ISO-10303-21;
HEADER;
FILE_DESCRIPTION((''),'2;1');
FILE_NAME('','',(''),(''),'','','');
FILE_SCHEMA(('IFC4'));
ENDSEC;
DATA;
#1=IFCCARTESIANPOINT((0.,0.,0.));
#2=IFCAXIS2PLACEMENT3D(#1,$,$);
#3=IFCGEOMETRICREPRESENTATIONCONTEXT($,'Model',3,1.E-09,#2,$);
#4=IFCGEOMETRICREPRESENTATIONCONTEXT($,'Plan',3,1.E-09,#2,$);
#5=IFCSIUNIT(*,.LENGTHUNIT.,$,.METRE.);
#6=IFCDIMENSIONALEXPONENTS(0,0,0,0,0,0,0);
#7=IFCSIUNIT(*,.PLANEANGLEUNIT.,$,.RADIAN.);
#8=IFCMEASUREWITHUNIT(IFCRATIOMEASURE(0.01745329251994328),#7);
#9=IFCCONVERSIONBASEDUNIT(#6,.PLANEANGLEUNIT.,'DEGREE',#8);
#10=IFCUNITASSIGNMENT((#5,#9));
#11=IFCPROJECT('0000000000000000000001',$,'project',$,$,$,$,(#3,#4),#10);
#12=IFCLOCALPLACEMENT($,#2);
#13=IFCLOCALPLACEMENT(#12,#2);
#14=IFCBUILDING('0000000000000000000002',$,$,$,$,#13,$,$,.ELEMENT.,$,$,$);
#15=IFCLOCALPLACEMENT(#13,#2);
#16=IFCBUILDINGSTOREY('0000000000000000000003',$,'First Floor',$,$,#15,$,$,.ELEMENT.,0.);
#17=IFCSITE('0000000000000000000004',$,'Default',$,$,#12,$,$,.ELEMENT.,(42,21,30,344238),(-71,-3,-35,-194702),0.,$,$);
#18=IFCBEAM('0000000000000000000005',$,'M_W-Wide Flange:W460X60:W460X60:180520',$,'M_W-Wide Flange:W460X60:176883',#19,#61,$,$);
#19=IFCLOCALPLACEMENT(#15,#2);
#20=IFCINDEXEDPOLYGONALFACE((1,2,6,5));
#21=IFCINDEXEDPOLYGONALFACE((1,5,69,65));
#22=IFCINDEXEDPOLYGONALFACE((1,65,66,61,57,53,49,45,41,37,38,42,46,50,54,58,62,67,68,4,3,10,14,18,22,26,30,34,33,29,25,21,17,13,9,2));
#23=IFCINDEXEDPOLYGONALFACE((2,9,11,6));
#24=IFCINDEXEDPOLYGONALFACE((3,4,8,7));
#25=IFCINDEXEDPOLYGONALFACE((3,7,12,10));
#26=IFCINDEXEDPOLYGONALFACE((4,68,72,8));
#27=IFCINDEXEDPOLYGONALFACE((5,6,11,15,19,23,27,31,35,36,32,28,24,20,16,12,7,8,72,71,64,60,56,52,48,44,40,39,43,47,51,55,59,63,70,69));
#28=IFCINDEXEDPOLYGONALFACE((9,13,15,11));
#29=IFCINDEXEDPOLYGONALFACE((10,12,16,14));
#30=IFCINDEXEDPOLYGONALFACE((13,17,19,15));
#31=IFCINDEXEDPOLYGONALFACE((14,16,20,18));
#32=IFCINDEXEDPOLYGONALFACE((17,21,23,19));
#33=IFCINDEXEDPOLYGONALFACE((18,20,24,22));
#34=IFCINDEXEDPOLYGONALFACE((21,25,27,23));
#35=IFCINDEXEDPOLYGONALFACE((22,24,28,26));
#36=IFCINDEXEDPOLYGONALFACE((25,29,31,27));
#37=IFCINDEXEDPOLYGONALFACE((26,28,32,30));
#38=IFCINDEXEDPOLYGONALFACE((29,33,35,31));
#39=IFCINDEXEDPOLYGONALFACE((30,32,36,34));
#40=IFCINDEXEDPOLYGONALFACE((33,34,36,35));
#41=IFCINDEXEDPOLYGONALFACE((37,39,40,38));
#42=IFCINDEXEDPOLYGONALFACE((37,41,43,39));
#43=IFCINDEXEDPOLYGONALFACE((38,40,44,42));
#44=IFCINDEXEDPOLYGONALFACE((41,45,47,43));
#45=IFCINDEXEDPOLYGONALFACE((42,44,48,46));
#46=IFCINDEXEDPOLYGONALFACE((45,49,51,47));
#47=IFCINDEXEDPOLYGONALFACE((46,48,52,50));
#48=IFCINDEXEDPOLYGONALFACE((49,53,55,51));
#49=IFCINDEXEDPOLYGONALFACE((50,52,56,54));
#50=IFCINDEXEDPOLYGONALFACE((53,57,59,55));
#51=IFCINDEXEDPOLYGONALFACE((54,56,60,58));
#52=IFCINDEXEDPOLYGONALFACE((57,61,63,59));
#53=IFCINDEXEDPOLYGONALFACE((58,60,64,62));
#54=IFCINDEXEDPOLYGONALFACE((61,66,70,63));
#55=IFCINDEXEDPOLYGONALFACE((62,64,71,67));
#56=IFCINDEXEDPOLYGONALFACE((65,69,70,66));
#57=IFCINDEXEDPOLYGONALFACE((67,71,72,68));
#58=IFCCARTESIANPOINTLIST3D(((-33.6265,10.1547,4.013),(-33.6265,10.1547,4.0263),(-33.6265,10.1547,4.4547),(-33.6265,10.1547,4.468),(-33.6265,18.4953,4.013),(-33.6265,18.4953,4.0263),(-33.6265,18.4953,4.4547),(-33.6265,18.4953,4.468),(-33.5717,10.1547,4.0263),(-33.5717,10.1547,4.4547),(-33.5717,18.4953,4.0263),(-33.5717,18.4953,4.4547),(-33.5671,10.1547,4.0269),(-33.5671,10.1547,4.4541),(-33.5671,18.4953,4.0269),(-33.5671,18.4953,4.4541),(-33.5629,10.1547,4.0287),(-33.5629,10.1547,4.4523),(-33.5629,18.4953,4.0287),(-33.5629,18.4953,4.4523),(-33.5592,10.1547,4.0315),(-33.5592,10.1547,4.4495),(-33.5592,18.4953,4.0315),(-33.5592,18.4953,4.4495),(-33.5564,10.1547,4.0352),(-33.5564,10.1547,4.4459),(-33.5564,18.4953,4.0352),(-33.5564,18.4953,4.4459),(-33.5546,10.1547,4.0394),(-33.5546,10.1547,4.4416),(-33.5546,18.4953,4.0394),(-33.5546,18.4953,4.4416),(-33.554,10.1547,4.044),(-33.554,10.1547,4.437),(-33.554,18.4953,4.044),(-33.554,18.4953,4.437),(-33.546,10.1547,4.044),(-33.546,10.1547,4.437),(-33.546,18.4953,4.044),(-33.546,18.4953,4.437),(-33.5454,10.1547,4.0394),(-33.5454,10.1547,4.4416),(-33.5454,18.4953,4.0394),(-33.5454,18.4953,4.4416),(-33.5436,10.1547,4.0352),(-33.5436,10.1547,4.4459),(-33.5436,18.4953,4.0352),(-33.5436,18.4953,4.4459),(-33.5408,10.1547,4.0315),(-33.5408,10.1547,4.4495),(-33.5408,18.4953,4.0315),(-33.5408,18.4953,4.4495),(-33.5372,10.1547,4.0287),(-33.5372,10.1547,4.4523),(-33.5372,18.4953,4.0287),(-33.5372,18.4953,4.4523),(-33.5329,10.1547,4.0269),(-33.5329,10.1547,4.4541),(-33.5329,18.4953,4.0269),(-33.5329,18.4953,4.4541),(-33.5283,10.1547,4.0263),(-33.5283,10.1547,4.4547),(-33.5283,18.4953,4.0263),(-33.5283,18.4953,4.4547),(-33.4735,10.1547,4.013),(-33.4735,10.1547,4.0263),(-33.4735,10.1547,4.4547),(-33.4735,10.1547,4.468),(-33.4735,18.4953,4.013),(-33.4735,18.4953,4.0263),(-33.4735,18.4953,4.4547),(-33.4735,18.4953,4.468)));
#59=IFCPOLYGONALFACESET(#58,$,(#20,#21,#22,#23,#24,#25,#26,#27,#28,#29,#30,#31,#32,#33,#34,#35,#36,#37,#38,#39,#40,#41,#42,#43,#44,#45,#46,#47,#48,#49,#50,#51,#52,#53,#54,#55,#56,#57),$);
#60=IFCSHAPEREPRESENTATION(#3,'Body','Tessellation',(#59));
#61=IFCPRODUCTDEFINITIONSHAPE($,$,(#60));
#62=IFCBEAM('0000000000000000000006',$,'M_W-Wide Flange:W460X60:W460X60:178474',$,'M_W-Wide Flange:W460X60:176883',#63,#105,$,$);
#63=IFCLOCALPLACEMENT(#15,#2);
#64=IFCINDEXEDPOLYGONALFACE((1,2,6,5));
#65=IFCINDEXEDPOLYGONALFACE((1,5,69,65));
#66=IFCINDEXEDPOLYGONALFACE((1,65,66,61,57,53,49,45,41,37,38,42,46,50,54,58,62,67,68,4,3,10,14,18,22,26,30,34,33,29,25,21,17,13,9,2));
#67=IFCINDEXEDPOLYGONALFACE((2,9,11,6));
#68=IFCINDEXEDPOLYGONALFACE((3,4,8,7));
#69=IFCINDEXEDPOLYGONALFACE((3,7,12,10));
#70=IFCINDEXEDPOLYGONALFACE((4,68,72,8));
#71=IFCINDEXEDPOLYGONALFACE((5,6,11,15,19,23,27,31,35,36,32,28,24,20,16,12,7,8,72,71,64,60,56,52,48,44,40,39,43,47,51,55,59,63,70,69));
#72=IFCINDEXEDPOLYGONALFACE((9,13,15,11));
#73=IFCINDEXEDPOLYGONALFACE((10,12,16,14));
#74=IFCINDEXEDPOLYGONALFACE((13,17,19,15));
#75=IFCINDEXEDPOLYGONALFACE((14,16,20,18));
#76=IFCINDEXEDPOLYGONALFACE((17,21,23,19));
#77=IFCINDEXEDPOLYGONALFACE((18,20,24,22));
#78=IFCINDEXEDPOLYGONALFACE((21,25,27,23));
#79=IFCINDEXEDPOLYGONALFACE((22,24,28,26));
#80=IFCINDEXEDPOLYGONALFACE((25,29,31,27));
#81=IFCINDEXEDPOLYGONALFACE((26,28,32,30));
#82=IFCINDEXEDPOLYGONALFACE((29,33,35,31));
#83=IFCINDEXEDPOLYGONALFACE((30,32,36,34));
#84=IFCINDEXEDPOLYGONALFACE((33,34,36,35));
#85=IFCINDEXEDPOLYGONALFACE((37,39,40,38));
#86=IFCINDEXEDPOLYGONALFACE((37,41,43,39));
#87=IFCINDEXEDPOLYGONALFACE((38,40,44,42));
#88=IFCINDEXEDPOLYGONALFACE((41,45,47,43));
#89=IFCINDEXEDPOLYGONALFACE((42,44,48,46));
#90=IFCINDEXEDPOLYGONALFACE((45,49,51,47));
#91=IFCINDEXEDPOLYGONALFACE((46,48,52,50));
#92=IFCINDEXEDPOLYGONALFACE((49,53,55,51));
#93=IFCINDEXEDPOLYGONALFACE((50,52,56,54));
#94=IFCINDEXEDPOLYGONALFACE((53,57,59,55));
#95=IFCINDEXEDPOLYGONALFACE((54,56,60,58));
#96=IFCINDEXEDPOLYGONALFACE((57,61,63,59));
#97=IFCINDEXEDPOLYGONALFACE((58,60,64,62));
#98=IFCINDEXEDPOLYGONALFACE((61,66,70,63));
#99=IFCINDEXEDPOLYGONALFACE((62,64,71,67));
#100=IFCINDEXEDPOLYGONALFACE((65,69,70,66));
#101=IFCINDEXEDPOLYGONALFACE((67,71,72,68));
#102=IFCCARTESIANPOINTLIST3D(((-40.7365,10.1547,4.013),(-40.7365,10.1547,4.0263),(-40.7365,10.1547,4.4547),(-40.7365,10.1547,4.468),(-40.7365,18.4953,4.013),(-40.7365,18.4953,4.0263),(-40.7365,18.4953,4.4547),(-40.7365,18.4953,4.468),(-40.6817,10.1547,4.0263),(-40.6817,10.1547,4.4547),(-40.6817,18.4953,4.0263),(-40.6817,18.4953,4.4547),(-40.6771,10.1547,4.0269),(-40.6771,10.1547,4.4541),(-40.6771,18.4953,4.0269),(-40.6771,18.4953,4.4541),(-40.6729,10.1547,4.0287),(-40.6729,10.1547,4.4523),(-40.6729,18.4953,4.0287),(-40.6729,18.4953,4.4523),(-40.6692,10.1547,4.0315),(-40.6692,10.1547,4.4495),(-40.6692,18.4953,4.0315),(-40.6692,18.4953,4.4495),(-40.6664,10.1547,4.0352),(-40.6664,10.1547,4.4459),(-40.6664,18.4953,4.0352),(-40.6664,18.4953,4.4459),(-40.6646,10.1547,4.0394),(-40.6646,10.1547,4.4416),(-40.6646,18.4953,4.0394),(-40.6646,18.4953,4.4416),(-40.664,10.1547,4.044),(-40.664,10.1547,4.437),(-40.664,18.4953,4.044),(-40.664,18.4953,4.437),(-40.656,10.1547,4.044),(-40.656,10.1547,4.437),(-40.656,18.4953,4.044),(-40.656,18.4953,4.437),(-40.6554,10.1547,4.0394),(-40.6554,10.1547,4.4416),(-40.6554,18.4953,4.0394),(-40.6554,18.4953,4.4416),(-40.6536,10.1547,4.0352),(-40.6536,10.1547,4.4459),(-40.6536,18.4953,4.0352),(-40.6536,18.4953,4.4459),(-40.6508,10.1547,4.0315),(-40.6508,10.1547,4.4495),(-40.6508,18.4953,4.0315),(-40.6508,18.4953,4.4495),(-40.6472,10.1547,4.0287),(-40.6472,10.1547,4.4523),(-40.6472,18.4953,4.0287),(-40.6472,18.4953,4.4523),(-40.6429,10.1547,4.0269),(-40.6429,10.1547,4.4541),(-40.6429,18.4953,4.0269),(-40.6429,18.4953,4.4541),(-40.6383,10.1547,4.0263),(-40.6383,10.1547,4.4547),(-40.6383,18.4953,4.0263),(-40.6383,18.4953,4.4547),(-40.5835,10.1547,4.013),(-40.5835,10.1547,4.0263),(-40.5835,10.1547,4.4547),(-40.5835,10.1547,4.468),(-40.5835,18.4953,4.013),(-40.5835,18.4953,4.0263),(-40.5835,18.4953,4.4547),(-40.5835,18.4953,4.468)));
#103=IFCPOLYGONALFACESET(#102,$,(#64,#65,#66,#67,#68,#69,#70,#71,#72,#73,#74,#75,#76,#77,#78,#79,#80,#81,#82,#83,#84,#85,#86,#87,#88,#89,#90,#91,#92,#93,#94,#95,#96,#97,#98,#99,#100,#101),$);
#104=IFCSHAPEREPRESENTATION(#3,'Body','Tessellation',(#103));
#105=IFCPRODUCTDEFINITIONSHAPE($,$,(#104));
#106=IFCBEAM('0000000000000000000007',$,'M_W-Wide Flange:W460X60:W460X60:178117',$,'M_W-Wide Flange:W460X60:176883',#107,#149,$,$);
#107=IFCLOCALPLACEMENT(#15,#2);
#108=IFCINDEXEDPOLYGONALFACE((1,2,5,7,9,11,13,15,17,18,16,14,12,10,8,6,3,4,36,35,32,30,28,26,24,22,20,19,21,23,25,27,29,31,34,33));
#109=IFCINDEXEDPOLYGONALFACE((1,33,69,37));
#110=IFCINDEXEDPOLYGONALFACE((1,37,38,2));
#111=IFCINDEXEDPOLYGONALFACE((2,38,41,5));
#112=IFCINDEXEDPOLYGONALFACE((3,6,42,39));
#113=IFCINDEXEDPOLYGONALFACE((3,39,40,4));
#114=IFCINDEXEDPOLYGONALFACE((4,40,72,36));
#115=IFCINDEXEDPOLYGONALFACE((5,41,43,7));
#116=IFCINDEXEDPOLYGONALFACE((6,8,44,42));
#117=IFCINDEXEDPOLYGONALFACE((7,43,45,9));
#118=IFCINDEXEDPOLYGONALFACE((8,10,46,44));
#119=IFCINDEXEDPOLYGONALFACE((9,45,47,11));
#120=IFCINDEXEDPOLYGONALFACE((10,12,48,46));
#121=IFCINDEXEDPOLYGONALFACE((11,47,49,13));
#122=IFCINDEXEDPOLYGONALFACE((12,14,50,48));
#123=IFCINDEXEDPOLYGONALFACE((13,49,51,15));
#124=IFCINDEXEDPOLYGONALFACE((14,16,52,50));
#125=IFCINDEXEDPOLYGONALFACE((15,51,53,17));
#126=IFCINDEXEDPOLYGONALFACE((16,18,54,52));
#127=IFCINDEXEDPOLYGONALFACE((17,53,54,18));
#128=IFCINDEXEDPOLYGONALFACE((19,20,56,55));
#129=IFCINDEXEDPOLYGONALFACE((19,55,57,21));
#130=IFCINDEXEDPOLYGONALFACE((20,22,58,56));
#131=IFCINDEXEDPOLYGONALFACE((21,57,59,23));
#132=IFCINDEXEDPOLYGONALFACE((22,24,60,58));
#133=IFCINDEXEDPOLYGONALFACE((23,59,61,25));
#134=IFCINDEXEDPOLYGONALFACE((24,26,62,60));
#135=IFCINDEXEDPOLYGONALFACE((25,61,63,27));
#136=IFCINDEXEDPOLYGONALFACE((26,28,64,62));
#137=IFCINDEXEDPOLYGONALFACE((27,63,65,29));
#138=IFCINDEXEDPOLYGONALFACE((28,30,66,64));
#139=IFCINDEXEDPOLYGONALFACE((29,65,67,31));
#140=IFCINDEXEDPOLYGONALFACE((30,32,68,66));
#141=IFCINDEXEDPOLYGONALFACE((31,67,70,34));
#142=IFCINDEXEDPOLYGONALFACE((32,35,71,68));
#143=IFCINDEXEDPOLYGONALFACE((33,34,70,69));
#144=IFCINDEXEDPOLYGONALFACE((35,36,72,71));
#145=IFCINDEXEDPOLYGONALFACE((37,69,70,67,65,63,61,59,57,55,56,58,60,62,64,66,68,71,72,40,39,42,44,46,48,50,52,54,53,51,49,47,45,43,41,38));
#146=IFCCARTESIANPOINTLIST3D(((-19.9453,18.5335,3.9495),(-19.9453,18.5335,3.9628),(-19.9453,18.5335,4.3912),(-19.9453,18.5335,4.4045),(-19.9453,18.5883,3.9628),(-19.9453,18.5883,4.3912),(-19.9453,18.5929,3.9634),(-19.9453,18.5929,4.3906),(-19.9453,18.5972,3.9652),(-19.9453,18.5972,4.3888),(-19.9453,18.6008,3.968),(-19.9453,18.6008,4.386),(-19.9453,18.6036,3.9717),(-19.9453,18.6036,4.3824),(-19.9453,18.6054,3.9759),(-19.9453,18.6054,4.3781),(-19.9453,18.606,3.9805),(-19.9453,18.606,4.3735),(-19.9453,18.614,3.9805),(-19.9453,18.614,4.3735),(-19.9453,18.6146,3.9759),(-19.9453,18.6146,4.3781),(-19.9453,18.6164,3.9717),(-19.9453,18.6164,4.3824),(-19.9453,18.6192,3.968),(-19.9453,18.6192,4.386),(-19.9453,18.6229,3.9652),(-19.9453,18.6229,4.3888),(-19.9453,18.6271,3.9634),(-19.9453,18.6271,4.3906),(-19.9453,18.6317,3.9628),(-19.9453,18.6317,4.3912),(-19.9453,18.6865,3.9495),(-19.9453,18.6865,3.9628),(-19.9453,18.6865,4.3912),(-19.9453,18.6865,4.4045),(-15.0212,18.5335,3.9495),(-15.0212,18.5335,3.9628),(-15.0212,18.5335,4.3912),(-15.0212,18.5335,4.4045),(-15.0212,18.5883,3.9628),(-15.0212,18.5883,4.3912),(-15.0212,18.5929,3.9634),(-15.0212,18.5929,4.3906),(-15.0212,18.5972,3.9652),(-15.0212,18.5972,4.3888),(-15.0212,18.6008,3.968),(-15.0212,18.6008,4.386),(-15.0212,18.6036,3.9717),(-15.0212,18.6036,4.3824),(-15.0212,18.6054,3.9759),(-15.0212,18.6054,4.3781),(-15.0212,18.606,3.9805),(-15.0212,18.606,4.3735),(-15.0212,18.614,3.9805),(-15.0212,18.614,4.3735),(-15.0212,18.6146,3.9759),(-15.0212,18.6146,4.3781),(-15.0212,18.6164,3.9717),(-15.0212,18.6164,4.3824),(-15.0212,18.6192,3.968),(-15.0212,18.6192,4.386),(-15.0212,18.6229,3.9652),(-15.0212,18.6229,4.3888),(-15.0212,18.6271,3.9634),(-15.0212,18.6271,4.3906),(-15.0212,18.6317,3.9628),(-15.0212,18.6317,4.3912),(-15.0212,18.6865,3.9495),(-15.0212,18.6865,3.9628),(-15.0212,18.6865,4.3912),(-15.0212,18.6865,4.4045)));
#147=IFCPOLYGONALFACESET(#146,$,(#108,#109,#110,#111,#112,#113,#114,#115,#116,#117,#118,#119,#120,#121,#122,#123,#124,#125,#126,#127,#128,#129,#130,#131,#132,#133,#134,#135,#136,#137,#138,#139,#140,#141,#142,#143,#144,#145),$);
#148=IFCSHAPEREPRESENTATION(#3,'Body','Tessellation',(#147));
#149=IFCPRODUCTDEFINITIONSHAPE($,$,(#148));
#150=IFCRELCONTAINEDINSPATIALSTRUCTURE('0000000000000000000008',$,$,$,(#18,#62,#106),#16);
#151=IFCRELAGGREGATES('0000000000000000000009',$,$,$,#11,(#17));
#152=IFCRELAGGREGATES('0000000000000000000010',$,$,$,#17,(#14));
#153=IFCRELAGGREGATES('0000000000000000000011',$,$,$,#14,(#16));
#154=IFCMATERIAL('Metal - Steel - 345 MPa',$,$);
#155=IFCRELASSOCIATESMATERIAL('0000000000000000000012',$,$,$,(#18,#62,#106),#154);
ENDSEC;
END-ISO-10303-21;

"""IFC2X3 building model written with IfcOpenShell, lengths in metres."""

from ifc_helpers import new_model, entity, si_unit, converted_unit, frame, frame_2d, origin, place, context, project, spatial, polyline, circle_curve, parameter, trimmed, segment, composite_curve, outline, extrude, material, element, save


model = new_model("IFC2X3")

# Units and contexts
model_context = context("Model", 3, precision=1e-09, world=origin())
plan_context = context("Plan", 3, precision=1e-09, world=origin())
ifc_project = project(units=[si_unit("LENGTHUNIT", "METRE"), converted_unit("PLANEANGLEUNIT", "DEGREE", entity("IfcRatioMeasure", 0.01745329251994328), si_unit("PLANEANGLEUNIT", "RADIAN"), dimensions=[0, 0, 0, 0, 0, 0, 0])], contexts=[model_context, plan_context])

# Site, building, storey
site_placement = place(None, origin())
site = spatial("IfcSite", under=ifc_project, at=site_placement, Name="Default", CompositionType="ELEMENT", RefLatitude=(42, 21, 30, 344238), RefLongitude=(-71, -3, -35, -194702), RefElevation=0.0)
building_placement = place(site_placement, origin())
building = spatial("IfcBuilding", under=site, at=building_placement, CompositionType="ELEMENT")
storey_placement = place(building_placement, origin())
storey = spatial("IfcBuildingStorey", under=building, at=storey_placement, Name="First Floor", CompositionType="ELEMENT", Elevation=0.0)

# Beams
ifc_material_1 = material(Name="Metal - Steel - 345 MPa")
beam_1_placement = place(storey_placement, frame((-33.55, 18.6116, 4.468), z_axis=(0.0, 0.0, 1.0), x_axis=(-1.0, 0.0, 0.0)))
element("IfcBeam", 1, at=beam_1_placement, inside=storey, material=ifc_material_1, Name="M_W-Wide Flange:W460X60:W460X60:180520", ObjectType="M_W-Wide Flange:W460X60:176883", context=model_context, shape_type="SweptSolid", body=[
    extrude(outline(composite_curve([segment(polyline([(0.2142, -0.0765), (0.2275, -0.0765)]), True, "CONTINUOUS"), segment(polyline([(0.2275, -0.0765), (0.2275, 0.0765)]), True, "CONTINUOUS"), segment(polyline([(0.2275, 0.0765), (0.2142, 0.0765)]), True, "CONTINUOUS"), segment(polyline([(0.2142, 0.0765), (0.2142, 0.0217)]), True, "CONTINUOUS"), segment(trimmed(circle_curve(frame_2d((0.1965, 0.0217), x_axis=(1.0, 0.0)), 0.0177), [parameter(270.0)], [parameter(360.0)], True, "PARAMETER"), False, "CONTINUOUS"), segment(polyline([(0.1965, 0.004), (-0.1965, 0.004)]), True, "CONTINUOUS"), segment(trimmed(circle_curve(frame_2d((-0.1965, 0.0217), x_axis=(0.0, -1.0)), 0.0177), [parameter(270.0)], [parameter(360.0)], True, "PARAMETER"), False, "CONTINUOUS"), segment(polyline([(-0.2142, 0.0217), (-0.2142, 0.0765)]), True, "CONTINUOUS"), segment(polyline([(-0.2142, 0.0765), (-0.2275, 0.0765)]), True, "CONTINUOUS"), segment(polyline([(-0.2275, 0.0765), (-0.2275, -0.0765)]), True, "CONTINUOUS"), segment(polyline([(-0.2275, -0.0765), (-0.2142, -0.0765)]), True, "CONTINUOUS"), segment(polyline([(-0.2142, -0.0765), (-0.2142, -0.0217)]), True, "CONTINUOUS"), segment(trimmed(circle_curve(frame_2d((-0.1965, -0.0217), x_axis=(-1.0, 0.0)), 0.0177), [parameter(270.0)], [parameter(360.0)], True, "PARAMETER"), False, "CONTINUOUS"), segment(polyline([(-0.1965, -0.004), (0.1965, -0.004)]), True, "CONTINUOUS"), segment(trimmed(circle_curve(frame_2d((0.1965, -0.0217), x_axis=(0.0, 1.0)), 0.0177), [parameter(270.0)], [parameter(0.0)], True, "PARAMETER"), False, "CONTINUOUS"), segment(polyline([(0.2142, -0.0217), (0.2142, -0.0765)]), True, "CONTINUOUS")], self_intersect=False)), frame((0.0, 8.4569, -0.2275), z_axis=(0.0, -1.0, 0.0), x_axis=(0.0, 0.0, -1.0)), (0.0, 0.0, 1.0), 8.3406),
])
beam_2_placement = place(storey_placement, frame((-40.66, 18.6116, 4.468), z_axis=(0.0, 0.0, 1.0), x_axis=(-1.0, 0.0, 0.0)))
element("IfcBeam", 2, at=beam_2_placement, inside=storey, material=ifc_material_1, Name="M_W-Wide Flange:W460X60:W460X60:178474", ObjectType="M_W-Wide Flange:W460X60:176883", context=model_context, shape_type="SweptSolid", body=[
    extrude(outline(composite_curve([segment(polyline([(0.2142, -0.0765), (0.2275, -0.0765)]), True, "CONTINUOUS"), segment(polyline([(0.2275, -0.0765), (0.2275, 0.0765)]), True, "CONTINUOUS"), segment(polyline([(0.2275, 0.0765), (0.2142, 0.0765)]), True, "CONTINUOUS"), segment(polyline([(0.2142, 0.0765), (0.2142, 0.0217)]), True, "CONTINUOUS"), segment(trimmed(circle_curve(frame_2d((0.1965, 0.0217), x_axis=(1.0, 0.0)), 0.0177), [parameter(270.0)], [parameter(360.0)], True, "PARAMETER"), False, "CONTINUOUS"), segment(polyline([(0.1965, 0.004), (-0.1965, 0.004)]), True, "CONTINUOUS"), segment(trimmed(circle_curve(frame_2d((-0.1965, 0.0217), x_axis=(0.0, -1.0)), 0.0177), [parameter(270.0)], [parameter(360.0)], True, "PARAMETER"), False, "CONTINUOUS"), segment(polyline([(-0.2142, 0.0217), (-0.2142, 0.0765)]), True, "CONTINUOUS"), segment(polyline([(-0.2142, 0.0765), (-0.2275, 0.0765)]), True, "CONTINUOUS"), segment(polyline([(-0.2275, 0.0765), (-0.2275, -0.0765)]), True, "CONTINUOUS"), segment(polyline([(-0.2275, -0.0765), (-0.2142, -0.0765)]), True, "CONTINUOUS"), segment(polyline([(-0.2142, -0.0765), (-0.2142, -0.0217)]), True, "CONTINUOUS"), segment(trimmed(circle_curve(frame_2d((-0.1965, -0.0217), x_axis=(-1.0, 0.0)), 0.0177), [parameter(270.0)], [parameter(360.0)], True, "PARAMETER"), False, "CONTINUOUS"), segment(polyline([(-0.1965, -0.004), (0.1965, -0.004)]), True, "CONTINUOUS"), segment(trimmed(circle_curve(frame_2d((0.1965, -0.0217), x_axis=(0.0, 1.0)), 0.0177), [parameter(270.0)], [parameter(0.0)], True, "PARAMETER"), False, "CONTINUOUS"), segment(polyline([(0.2142, -0.0217), (0.2142, -0.0765)]), True, "CONTINUOUS")], self_intersect=False)), frame((0.0, 8.4569, -0.2275), z_axis=(0.0, -1.0, 0.0), x_axis=(0.0, 0.0, -1.0)), (0.0, 0.0, 1.0), 8.3406),
])
beam_3_placement = place(storey_placement, frame((-20.0626, 18.61, 4.4045), z_axis=(0.0, 0.0, 1.0), x_axis=(0.0, -1.0, 0.0)))
element("IfcBeam", 3, at=beam_3_placement, inside=storey, material=ifc_material_1, Name="M_W-Wide Flange:W460X60:W460X60:178117", ObjectType="M_W-Wide Flange:W460X60:176883", context=model_context, shape_type="SweptSolid", body=[
    extrude(outline(composite_curve([segment(polyline([(-0.0765, -0.2142), (-0.0765, -0.2275)]), True, "CONTINUOUS"), segment(polyline([(-0.0765, -0.2275), (0.0765, -0.2275)]), True, "CONTINUOUS"), segment(polyline([(0.0765, -0.2275), (0.0765, -0.2142)]), True, "CONTINUOUS"), segment(polyline([(0.0765, -0.2142), (0.0217, -0.2142)]), True, "CONTINUOUS"), segment(trimmed(circle_curve(frame_2d((0.0217, -0.1965), x_axis=(0.0, -1.0)), 0.0177), [parameter(270.0)], [parameter(360.0)], True, "PARAMETER"), False, "CONTINUOUS"), segment(polyline([(0.004, -0.1965), (0.004, 0.1965)]), True, "CONTINUOUS"), segment(trimmed(circle_curve(frame_2d((0.0217, 0.1965), x_axis=(-1.0, 0.0)), 0.0177), [parameter(270.0)], [parameter(360.0)], True, "PARAMETER"), False, "CONTINUOUS"), segment(polyline([(0.0217, 0.2142), (0.0765, 0.2142)]), True, "CONTINUOUS"), segment(polyline([(0.0765, 0.2142), (0.0765, 0.2275)]), True, "CONTINUOUS"), segment(polyline([(0.0765, 0.2275), (-0.0765, 0.2275)]), True, "CONTINUOUS"), segment(polyline([(-0.0765, 0.2275), (-0.0765, 0.2142)]), True, "CONTINUOUS"), segment(polyline([(-0.0765, 0.2142), (-0.0217, 0.2142)]), True, "CONTINUOUS"), segment(trimmed(circle_curve(frame_2d((-0.0217, 0.1965), x_axis=(0.0, 1.0)), 0.0177), [parameter(270.0)], [parameter(360.0)], True, "PARAMETER"), False, "CONTINUOUS"), segment(polyline([(-0.004, 0.1965), (-0.004, -0.1965)]), True, "CONTINUOUS"), segment(trimmed(circle_curve(frame_2d((-0.0217, -0.1965), x_axis=(1.0, 0.0)), 0.0177), [parameter(270.0)], [parameter(0.0)], True, "PARAMETER"), False, "CONTINUOUS"), segment(polyline([(-0.0217, -0.2142), (-0.0765, -0.2142)]), True, "CONTINUOUS")], self_intersect=False)), frame((0.0, 0.1173, -0.2275), z_axis=(0.0, -1.0, 0.0), x_axis=(1.0, 0.0, 0.0)), (0.0, 0.0, -1.0), 4.9241),
])

save(model, "model.ifc")
